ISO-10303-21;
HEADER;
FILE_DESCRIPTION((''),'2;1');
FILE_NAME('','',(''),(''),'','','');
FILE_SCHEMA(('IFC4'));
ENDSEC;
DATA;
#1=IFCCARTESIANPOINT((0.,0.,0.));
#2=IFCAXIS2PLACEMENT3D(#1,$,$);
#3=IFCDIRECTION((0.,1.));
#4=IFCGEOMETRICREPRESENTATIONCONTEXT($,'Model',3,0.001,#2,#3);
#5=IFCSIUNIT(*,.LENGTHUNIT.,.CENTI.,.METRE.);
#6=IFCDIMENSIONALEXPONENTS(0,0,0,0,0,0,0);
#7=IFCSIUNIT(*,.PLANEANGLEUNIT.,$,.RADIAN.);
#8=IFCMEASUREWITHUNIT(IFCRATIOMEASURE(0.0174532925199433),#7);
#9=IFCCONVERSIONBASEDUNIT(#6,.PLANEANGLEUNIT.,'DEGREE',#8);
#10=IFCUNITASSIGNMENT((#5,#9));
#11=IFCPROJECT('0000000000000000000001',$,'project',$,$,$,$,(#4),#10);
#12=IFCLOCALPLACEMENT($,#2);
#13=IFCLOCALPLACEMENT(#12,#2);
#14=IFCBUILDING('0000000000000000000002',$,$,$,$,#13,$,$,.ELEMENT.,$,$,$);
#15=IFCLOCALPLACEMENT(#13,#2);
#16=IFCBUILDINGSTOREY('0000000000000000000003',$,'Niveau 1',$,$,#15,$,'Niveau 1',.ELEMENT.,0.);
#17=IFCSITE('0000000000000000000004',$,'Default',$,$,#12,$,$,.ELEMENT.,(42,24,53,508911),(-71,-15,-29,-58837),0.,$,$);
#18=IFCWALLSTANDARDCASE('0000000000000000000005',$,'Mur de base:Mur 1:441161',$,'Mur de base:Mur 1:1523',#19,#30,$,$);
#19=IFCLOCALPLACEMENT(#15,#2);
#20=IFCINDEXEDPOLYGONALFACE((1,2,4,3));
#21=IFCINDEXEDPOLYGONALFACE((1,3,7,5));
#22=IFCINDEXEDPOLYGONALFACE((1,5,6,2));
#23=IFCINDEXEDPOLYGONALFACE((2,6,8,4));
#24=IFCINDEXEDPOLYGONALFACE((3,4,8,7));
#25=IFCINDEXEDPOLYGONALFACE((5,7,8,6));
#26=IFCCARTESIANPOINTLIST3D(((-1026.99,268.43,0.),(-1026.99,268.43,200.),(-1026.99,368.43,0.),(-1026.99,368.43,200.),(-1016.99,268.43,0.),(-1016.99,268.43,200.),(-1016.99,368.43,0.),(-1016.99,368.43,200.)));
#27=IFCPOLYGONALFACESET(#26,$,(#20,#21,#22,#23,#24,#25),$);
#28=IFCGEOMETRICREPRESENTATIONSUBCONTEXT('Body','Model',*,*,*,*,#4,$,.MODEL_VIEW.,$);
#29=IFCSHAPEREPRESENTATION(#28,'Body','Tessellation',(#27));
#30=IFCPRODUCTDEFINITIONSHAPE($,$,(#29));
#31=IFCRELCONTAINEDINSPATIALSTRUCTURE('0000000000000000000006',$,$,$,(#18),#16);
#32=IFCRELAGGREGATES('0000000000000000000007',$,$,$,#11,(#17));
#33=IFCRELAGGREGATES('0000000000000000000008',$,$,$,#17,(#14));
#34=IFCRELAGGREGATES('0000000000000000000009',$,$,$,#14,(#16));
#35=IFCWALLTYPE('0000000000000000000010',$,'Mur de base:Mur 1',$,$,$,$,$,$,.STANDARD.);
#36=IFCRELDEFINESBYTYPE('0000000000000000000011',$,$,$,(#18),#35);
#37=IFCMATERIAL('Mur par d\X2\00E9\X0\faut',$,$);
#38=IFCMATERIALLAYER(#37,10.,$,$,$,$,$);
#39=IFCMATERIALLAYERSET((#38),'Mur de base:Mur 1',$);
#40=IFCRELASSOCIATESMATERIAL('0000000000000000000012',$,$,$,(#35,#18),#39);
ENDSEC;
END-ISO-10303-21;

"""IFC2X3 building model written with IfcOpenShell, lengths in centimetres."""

from ifc_helpers import new_model, entity, si_unit, converted_unit, direction, frame, frame_2d, origin, place, context, subcontext, project, spatial, rectangle, extrude, material, layer, layer_set, layer_usage, type_object, element, save


model = new_model("IFC2X3")

# Units and contexts
model_context = context("Model", 3, precision=0.001, world=origin(), true_north=direction((0.0, 1.0)))
body_context = subcontext(model_context, "Body", "Model", "MODEL_VIEW")
ifc_project = project(units=[si_unit("LENGTHUNIT", "METRE", prefix="CENTI"), converted_unit("PLANEANGLEUNIT", "DEGREE", entity("IfcRatioMeasure", 0.0174532925199433), si_unit("PLANEANGLEUNIT", "RADIAN"), dimensions=[0, 0, 0, 0, 0, 0, 0])], contexts=[model_context])

# Site, building, storey
site_placement = place(None, origin())
site = spatial("IfcSite", under=ifc_project, at=site_placement, Name="Default", CompositionType="ELEMENT", RefLatitude=(42, 24, 53, 508911), RefLongitude=(-71, -15, -29, -58837), RefElevation=0.0)
building_placement = place(site_placement, origin())
building = spatial("IfcBuilding", under=site, at=building_placement, CompositionType="ELEMENT")
storey_placement = place(building_placement, origin())
storey = spatial("IfcBuildingStorey", under=building, at=storey_placement, Name="Niveau 1", LongName="Niveau 1", CompositionType="ELEMENT", Elevation=0.0)

# Wall
ifc_material = material(Name="Mur par défaut")
ifc_layer = layer(ifc_material, 10.0)
ifc_layer_set = layer_set([ifc_layer], Name="Mur de base:Mur 1")
ifc_layer_usage = layer_usage(ifc_layer_set, "AXIS2", "NEGATIVE", 5.0)
wall_type = type_object("IfcWallType", Name="Mur de base:Mur 1", PredefinedType="STANDARD", material=ifc_layer_set)
wall_placement = place(storey_placement, frame((-1021.99, 268.43, 0.0), z_axis=(0.0, 0.0, 1.0), x_axis=(0.0, 1.0, 0.0)))
element("IfcWallStandardCase", 1, at=wall_placement, inside=storey, type_object=wall_type, material=ifc_layer_usage, Name="Mur de base:Mur 1:441161", ObjectType="Mur de base:Mur 1:1523", context=body_context, shape_type="SweptSolid", body=[
    extrude(rectangle(XDim=100.0, YDim=10.0, at=frame_2d((50.0, 0.0), x_axis=(-1.0, 0.0))), origin(), (0.0, 0.0, 1.0), 200.0),
])

save(model, "model.ifc")
